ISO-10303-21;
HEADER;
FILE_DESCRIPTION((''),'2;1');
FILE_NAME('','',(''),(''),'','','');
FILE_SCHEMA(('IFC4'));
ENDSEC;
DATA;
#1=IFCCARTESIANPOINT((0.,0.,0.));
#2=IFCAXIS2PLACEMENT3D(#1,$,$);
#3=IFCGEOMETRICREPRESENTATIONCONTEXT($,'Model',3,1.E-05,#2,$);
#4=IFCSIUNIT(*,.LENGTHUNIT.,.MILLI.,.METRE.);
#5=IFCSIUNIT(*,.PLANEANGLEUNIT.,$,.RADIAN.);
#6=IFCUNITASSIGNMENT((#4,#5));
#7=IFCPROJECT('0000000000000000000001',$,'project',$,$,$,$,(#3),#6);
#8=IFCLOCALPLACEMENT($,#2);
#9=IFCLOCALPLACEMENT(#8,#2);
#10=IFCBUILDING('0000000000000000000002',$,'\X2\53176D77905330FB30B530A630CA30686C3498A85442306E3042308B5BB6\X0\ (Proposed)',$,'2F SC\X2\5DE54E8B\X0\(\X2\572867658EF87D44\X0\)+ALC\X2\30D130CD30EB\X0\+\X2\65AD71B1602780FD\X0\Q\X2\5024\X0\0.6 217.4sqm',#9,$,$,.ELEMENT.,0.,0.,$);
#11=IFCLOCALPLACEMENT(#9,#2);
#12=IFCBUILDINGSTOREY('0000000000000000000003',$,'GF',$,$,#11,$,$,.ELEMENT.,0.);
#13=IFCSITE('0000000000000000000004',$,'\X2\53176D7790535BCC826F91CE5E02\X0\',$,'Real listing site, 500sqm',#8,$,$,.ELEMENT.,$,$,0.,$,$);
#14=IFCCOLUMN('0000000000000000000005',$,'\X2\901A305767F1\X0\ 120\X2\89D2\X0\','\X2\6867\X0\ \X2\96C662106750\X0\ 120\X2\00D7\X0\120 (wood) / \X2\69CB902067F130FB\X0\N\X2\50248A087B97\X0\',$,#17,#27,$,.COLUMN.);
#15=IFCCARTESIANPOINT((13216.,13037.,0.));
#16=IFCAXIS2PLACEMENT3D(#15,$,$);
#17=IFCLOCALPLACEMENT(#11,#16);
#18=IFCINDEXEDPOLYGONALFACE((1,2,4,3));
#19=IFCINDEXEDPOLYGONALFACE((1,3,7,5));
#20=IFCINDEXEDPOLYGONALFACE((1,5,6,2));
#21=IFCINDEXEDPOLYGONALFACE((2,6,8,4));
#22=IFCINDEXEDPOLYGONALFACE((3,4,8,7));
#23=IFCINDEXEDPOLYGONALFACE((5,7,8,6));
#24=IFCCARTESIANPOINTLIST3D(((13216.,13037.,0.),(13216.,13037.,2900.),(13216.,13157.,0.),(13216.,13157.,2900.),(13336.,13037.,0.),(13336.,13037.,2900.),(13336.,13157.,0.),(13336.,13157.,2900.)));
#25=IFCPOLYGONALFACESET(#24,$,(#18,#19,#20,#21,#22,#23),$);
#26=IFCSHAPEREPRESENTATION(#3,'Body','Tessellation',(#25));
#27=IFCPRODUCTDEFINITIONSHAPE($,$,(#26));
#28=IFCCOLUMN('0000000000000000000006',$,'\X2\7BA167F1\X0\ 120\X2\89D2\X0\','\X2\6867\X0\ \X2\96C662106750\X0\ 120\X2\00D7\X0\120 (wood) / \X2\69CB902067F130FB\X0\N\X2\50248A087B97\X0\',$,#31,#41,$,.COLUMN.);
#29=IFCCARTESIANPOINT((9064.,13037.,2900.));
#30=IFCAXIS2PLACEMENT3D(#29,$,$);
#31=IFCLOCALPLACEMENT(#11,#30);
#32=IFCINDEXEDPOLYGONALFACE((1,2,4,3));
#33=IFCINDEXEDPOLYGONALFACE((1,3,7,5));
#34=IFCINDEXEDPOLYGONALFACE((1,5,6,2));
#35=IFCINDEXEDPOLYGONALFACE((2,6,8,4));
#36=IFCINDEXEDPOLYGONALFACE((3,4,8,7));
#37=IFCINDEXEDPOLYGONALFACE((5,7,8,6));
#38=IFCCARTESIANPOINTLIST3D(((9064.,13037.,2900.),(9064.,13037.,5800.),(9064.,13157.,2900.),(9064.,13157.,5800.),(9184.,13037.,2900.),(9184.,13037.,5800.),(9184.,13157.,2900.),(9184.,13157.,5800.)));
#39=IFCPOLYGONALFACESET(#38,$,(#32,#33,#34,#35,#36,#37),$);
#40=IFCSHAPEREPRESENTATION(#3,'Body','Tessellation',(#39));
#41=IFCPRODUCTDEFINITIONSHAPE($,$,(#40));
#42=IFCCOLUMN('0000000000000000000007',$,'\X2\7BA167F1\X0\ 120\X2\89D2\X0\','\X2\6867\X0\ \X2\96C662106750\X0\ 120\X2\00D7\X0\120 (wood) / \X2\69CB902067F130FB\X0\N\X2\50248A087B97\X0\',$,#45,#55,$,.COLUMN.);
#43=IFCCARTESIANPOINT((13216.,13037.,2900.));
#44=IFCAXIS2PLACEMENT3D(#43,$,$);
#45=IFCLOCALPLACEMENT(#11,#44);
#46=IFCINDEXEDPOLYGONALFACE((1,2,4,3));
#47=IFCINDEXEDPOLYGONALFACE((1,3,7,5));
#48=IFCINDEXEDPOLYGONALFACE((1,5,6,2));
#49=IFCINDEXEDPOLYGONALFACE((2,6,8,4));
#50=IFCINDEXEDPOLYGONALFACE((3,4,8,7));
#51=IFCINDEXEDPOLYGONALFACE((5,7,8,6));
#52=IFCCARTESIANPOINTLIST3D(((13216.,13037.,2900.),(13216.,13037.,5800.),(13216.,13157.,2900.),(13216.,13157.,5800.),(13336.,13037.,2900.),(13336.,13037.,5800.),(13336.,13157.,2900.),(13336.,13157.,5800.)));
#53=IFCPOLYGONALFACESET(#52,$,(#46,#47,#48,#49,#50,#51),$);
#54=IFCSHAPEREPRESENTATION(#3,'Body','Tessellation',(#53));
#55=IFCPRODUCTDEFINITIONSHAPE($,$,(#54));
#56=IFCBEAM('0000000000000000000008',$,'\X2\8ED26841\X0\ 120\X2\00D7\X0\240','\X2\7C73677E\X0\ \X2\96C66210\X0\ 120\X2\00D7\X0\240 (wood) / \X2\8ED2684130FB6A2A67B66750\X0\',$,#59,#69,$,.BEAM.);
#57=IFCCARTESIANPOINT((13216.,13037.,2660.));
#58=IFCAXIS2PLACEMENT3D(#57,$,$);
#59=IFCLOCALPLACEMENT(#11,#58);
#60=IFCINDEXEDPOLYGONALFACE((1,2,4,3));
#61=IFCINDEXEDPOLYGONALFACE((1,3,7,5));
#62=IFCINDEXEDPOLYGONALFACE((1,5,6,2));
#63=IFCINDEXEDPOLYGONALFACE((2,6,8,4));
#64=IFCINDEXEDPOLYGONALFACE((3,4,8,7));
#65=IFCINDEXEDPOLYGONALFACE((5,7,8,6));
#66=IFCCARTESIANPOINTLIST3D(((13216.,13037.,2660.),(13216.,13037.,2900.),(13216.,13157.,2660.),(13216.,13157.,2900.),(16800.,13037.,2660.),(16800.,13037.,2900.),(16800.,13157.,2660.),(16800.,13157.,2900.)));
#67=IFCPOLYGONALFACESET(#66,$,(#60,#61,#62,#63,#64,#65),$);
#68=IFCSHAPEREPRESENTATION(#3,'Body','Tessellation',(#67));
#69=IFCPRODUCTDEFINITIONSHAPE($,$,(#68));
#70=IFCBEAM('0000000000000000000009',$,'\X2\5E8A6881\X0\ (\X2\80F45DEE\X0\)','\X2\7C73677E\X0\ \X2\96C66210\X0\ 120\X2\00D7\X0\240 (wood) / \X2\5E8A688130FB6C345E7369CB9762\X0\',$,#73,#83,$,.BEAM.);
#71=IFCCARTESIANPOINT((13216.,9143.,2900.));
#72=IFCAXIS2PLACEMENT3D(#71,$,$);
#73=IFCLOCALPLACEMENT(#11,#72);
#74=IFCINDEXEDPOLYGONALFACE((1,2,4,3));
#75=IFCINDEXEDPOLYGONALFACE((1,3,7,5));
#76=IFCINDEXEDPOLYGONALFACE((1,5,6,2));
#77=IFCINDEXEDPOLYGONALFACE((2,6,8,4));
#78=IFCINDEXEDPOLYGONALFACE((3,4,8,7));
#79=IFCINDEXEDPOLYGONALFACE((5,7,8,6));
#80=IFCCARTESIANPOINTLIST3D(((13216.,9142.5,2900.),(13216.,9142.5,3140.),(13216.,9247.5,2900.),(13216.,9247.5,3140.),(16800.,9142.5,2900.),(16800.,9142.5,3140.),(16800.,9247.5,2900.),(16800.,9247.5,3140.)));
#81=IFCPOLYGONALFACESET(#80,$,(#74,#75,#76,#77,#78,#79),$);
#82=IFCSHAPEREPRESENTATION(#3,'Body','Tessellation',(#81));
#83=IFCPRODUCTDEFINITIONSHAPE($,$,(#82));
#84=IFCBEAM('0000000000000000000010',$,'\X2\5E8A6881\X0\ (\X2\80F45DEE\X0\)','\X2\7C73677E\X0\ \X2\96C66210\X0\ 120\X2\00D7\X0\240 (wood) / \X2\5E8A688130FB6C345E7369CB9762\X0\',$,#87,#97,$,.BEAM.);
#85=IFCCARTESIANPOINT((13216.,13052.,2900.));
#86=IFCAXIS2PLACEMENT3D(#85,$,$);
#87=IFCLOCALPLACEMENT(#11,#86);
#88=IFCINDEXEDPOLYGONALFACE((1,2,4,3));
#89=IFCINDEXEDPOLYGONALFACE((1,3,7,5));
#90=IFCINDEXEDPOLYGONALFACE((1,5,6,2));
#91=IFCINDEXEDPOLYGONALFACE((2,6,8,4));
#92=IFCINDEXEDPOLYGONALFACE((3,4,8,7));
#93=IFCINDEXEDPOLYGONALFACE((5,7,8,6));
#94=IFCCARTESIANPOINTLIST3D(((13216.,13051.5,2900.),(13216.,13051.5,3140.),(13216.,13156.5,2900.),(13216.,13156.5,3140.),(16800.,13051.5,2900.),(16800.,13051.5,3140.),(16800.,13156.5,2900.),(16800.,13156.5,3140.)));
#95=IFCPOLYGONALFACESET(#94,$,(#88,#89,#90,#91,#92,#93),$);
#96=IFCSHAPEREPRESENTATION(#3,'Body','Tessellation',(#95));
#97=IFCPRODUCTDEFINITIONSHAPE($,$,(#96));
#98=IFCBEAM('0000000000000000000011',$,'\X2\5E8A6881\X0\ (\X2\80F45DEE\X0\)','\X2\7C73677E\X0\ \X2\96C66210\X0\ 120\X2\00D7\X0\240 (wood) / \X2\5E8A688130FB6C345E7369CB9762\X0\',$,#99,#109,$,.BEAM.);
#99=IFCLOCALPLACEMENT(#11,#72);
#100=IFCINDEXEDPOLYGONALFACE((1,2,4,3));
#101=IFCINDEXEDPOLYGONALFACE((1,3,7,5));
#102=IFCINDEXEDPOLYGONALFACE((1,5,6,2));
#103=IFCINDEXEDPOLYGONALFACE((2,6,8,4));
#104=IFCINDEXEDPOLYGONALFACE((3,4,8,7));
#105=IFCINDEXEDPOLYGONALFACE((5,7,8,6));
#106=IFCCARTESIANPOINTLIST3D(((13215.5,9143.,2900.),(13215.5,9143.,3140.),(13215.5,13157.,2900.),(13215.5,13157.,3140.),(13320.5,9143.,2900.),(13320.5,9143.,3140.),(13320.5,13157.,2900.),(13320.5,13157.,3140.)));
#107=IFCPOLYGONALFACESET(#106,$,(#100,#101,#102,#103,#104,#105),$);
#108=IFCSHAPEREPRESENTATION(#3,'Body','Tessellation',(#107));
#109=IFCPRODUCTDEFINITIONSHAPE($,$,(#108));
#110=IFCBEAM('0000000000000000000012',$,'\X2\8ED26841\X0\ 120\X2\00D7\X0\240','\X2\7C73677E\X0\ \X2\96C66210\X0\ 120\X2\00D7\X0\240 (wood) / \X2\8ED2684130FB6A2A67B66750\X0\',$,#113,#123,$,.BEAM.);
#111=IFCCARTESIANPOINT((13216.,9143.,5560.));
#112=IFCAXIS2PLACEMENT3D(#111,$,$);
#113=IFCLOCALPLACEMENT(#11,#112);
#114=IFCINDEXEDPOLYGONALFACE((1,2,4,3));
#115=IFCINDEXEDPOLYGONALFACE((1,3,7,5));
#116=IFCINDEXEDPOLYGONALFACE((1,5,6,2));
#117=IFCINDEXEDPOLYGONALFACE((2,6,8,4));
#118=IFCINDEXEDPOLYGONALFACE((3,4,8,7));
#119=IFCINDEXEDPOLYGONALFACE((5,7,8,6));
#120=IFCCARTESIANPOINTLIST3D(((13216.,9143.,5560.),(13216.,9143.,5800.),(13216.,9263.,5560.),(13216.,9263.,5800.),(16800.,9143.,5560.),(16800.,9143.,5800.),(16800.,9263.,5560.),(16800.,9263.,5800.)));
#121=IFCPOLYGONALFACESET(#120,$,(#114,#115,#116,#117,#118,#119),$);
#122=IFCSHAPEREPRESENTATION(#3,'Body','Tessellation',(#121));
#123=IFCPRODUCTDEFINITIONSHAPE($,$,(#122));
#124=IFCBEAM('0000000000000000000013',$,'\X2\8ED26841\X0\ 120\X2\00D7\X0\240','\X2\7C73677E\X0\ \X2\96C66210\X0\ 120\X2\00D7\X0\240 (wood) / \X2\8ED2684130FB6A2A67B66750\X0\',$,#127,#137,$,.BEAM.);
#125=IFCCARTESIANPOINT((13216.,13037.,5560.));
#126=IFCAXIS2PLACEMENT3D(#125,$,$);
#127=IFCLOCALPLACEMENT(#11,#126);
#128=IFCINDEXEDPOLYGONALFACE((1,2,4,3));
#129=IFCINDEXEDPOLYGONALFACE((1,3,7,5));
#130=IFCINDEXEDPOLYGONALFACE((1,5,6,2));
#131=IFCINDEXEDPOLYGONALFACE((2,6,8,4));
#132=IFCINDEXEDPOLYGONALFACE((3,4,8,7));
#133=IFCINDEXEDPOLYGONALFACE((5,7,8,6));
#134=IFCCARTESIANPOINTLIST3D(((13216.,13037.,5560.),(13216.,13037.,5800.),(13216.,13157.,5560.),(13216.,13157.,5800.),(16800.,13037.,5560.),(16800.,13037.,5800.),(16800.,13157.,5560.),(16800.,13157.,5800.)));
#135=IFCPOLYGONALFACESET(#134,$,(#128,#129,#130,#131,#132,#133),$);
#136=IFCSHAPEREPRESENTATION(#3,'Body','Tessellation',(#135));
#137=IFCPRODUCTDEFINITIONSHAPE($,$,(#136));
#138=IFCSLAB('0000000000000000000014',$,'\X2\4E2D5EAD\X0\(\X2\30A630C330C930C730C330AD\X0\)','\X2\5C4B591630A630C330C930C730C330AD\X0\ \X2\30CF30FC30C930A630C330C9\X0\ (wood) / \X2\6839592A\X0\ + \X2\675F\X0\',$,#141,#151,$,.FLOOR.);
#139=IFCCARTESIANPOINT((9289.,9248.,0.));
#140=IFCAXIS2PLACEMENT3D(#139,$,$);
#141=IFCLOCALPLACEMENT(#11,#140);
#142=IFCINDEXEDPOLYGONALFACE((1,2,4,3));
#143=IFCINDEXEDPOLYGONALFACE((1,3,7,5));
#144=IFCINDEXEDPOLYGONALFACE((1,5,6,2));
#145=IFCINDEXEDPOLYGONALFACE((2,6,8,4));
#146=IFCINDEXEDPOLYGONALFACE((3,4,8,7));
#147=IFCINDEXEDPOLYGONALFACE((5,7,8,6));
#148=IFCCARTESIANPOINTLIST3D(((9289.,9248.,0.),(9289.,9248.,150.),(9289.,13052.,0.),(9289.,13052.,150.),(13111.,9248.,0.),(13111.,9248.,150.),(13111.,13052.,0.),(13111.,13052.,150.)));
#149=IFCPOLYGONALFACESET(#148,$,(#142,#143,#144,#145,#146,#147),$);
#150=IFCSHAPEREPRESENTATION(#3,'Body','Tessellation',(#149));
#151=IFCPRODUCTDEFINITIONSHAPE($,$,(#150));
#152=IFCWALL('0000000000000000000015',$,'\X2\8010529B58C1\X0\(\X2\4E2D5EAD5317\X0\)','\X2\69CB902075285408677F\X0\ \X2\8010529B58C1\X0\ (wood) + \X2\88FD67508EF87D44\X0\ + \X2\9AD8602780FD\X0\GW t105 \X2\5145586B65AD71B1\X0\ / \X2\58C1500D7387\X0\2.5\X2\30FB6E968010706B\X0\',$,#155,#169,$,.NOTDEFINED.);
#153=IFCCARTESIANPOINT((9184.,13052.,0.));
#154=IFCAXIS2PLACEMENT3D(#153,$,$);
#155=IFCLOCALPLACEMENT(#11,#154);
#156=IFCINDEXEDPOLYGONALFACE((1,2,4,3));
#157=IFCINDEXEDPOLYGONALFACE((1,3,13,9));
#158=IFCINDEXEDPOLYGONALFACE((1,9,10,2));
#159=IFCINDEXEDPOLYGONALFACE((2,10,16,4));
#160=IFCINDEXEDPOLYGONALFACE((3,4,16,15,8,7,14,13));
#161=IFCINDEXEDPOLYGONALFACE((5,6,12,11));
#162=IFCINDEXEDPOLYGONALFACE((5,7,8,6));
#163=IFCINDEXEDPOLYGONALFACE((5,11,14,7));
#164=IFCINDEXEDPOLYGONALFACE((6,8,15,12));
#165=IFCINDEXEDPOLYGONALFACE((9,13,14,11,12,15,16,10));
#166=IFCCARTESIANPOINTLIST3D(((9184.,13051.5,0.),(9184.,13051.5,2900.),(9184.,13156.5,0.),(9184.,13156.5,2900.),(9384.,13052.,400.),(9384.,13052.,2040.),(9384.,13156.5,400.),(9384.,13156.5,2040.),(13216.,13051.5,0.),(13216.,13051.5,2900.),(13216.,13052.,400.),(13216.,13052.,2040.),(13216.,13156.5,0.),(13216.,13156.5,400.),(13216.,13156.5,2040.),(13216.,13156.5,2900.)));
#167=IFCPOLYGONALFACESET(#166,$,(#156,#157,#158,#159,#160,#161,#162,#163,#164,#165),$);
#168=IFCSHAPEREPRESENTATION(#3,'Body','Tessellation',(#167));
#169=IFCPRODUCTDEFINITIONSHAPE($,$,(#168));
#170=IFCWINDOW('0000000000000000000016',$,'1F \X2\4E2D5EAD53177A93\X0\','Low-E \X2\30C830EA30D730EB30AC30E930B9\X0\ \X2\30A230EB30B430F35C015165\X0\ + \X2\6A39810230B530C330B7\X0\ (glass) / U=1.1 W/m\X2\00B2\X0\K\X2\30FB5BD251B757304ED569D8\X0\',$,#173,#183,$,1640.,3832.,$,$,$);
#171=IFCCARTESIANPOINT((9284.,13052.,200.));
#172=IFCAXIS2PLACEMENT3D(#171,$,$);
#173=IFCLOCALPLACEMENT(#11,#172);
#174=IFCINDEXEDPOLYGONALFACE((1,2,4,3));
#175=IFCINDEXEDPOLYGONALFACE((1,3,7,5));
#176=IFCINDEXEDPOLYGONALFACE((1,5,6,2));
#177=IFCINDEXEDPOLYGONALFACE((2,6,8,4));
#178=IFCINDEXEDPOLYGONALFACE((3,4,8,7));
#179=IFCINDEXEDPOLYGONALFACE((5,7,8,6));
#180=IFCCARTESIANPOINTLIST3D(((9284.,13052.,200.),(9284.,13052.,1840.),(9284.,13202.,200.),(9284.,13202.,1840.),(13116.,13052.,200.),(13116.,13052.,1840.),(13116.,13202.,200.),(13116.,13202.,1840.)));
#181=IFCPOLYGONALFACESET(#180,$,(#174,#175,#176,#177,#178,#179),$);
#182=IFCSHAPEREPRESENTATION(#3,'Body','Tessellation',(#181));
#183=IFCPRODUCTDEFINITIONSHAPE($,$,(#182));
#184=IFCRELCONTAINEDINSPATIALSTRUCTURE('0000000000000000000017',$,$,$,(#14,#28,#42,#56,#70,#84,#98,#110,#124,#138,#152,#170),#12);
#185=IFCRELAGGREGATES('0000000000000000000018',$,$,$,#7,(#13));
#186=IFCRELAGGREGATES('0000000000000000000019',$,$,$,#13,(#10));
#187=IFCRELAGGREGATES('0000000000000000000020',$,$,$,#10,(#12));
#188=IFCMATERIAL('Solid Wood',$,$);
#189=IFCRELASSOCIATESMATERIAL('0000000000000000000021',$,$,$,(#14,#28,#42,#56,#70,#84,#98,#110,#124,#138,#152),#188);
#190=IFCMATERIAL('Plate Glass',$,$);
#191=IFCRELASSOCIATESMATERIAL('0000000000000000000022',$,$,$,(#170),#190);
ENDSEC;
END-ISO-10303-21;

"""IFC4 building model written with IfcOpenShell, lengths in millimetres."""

from ifc_helpers import new_model, si_unit, frame, frame_2d, origin, place, context, project, spatial, rectangle, extrude, material, element, fill, save


model = new_model("IFC4")

# Units and contexts
model_context = context("Model", 3, precision=1e-05, world=origin())
ifc_project = project(units=[si_unit("LENGTHUNIT", "METRE", prefix="MILLI"), si_unit("PLANEANGLEUNIT", "RADIAN")], contexts=[model_context])

# Site, building, storey
site_placement = place(None, origin())
site = spatial("IfcSite", under=ifc_project, at=site_placement, Name="北海道富良野市", ObjectType="Real listing site, 500sqm", CompositionType="ELEMENT", RefElevation=0.0)
building_placement = place(site_placement, origin())
building = spatial("IfcBuilding", under=site, at=building_placement, Name="北海道・サウナと水風呂のある家 (Proposed)", ObjectType="2F SC工事(在来軸組)+ALCパネル+断熱性能Q値0.6 217.4sqm", CompositionType="ELEMENT", ElevationOfRefHeight=0.0, ElevationOfTerrain=0.0)
storey_placement = place(building_placement, origin())
storey = spatial("IfcBuildingStorey", under=building, at=storey_placement, Name="GF", CompositionType="ELEMENT", Elevation=0.0)

# Columns
ifc_material_1 = material(Name="Solid Wood")
column_1_placement = place(storey_placement, frame((13216.0, 13037.0, 0.0)))
element("IfcColumn", 1, at=column_1_placement, inside=storey, material=ifc_material_1, Name="通し柱 120角", Description="桧 集成材 120×120 (wood) / 構造柱・N値計算", PredefinedType="COLUMN", context=model_context, shape_type="SweptSolid", body=[
    extrude(rectangle(XDim=120.0, YDim=120.0, at=frame_2d((60.0, 60.0))), frame((13216.0, 13037.0, 0.0)), (0.0, 0.0, 1.0), 2900.0),
])
column_2_placement = place(storey_placement, frame((9064.0, 13037.0, 2900.0)))
element("IfcColumn", 2, at=column_2_placement, inside=storey, material=ifc_material_1, Name="管柱 120角", Description="桧 集成材 120×120 (wood) / 構造柱・N値計算", PredefinedType="COLUMN", context=model_context, shape_type="SweptSolid", body=[
    extrude(rectangle(XDim=120.0, YDim=120.0, at=frame_2d((60.0, 60.0))), frame((9064.0, 13037.0, 2900.0)), (0.0, 0.0, 1.0), 2900.0),
])
column_3_placement = place(storey_placement, frame((13216.0, 13037.0, 2900.0)))
element("IfcColumn", 3, at=column_3_placement, inside=storey, material=ifc_material_1, Name="管柱 120角", Description="桧 集成材 120×120 (wood) / 構造柱・N値計算", PredefinedType="COLUMN", context=model_context, shape_type="SweptSolid", body=[
    extrude(rectangle(XDim=120.0, YDim=120.0, at=frame_2d((60.0, 60.0))), frame((13216.0, 13037.0, 2900.0)), (0.0, 0.0, 1.0), 2900.0),
])

# Beams
beam_1_placement = place(storey_placement, frame((13216.0, 13037.0, 2660.0)))
element("IfcBeam", 4, at=beam_1_placement, inside=storey, material=ifc_material_1, Name="軒桁 120×240", Description="米松 集成 120×240 (wood) / 軒桁・横架材", PredefinedType="BEAM", context=model_context, shape_type="SweptSolid", body=[
    extrude(rectangle(XDim=3584.0, YDim=120.0, at=frame_2d((1792.0, 60.0))), frame((13216.0, 13037.0, 2660.0)), (0.0, 0.0, 1.0), 240.0),
])
beam_2_placement = place(storey_placement, frame((13216.0, 9143.0, 2900.0)))
element("IfcBeam", 5, at=beam_2_placement, inside=storey, material=ifc_material_1, Name="床梁 (胴差)", Description="米松 集成 120×240 (wood) / 床梁・水平構面", PredefinedType="BEAM", context=model_context, shape_type="SweptSolid", body=[
    extrude(rectangle(XDim=3584.0, YDim=105.0, at=frame_2d((1792.0, 52.0))), frame((13216.0, 9143.0, 2900.0)), (0.0, 0.0, 1.0), 240.0),
])
beam_3_placement = place(storey_placement, frame((13216.0, 13052.0, 2900.0)))
element("IfcBeam", 6, at=beam_3_placement, inside=storey, material=ifc_material_1, Name="床梁 (胴差)", Description="米松 集成 120×240 (wood) / 床梁・水平構面", PredefinedType="BEAM", context=model_context, shape_type="SweptSolid", body=[
    extrude(rectangle(XDim=3584.0, YDim=105.0, at=frame_2d((1792.0, 52.0))), frame((13216.0, 13052.0, 2900.0)), (0.0, 0.0, 1.0), 240.0),
])
beam_4_placement = place(storey_placement, frame((13216.0, 9143.0, 2900.0)))
element("IfcBeam", 7, at=beam_4_placement, inside=storey, material=ifc_material_1, Name="床梁 (胴差)", Description="米松 集成 120×240 (wood) / 床梁・水平構面", PredefinedType="BEAM", context=model_context, shape_type="SweptSolid", body=[
    extrude(rectangle(XDim=105.0, YDim=4014.0, at=frame_2d((52.0, 2007.0))), frame((13216.0, 9143.0, 2900.0)), (0.0, 0.0, 1.0), 240.0),
])
beam_5_placement = place(storey_placement, frame((13216.0, 9143.0, 5560.0)))
element("IfcBeam", 8, at=beam_5_placement, inside=storey, material=ifc_material_1, Name="軒桁 120×240", Description="米松 集成 120×240 (wood) / 軒桁・横架材", PredefinedType="BEAM", context=model_context, shape_type="SweptSolid", body=[
    extrude(rectangle(XDim=3584.0, YDim=120.0, at=frame_2d((1792.0, 60.0))), frame((13216.0, 9143.0, 5560.0)), (0.0, 0.0, 1.0), 240.0),
])
beam_6_placement = place(storey_placement, frame((13216.0, 13037.0, 5560.0)))
element("IfcBeam", 9, at=beam_6_placement, inside=storey, material=ifc_material_1, Name="軒桁 120×240", Description="米松 集成 120×240 (wood) / 軒桁・横架材", PredefinedType="BEAM", context=model_context, shape_type="SweptSolid", body=[
    extrude(rectangle(XDim=3584.0, YDim=120.0, at=frame_2d((1792.0, 60.0))), frame((13216.0, 13037.0, 5560.0)), (0.0, 0.0, 1.0), 240.0),
])

# Slab
slab_placement = place(storey_placement, frame((9289.0, 9248.0, 0.0)))
element("IfcSlab", 10, at=slab_placement, inside=storey, material=ifc_material_1, Name="中庭(ウッドデッキ)", Description="屋外ウッドデッキ ハードウッド (wood) / 根太 + 束", PredefinedType="FLOOR", context=model_context, shape_type="SweptSolid", body=[
    extrude(rectangle(XDim=3822.0, YDim=3804.0, at=frame_2d((1911.0, 1902.0))), frame((9289.0, 9248.0, 0.0)), (0.0, 0.0, 1.0), 150.0),
])

# Wall, opening, window
wall_1_placement = place(storey_placement, frame((9184.0, 13052.0, 0.0)))
wall_1 = element("IfcWall", 11, at=wall_1_placement, inside=storey, material=ifc_material_1, Name="耐力壁(中庭北)", Description="構造用合板 耐力壁 (wood) + 製材軸組 + 高性能GW t105 充填断熱 / 壁倍率2.5・準耐火", PredefinedType="NOTDEFINED", context=model_context, shape_type="SweptSolid", body=[
    extrude(rectangle(XDim=4032.0, YDim=105.0, at=frame_2d((2016.0, 52.0))), frame((9184.0, 13052.0, 0.0)), (0.0, 0.0, 1.0), 2900.0),
])
opening_1_placement = place(storey_placement, frame((9284.0, 13052.0, 200.0)))
opening_1 = element("IfcOpeningElement", 12, at=opening_1_placement, cuts=wall_1, PredefinedType="NOTDEFINED", context=model_context, shape_type="SweptSolid", body=[
    extrude(rectangle(XDim=3832.0, YDim=150.0, at=frame_2d((1916.0, 75.0))), frame((9284.0, 13052.0, 200.0)), (0.0, 0.0, 1.0), 1640.0),
])
ifc_material_2 = material(Name="Plate Glass")
window_1_placement = place(storey_placement, frame((9284.0, 13052.0, 200.0)))
window_1 = element("IfcWindow", 13, at=window_1_placement, inside=storey, material=ifc_material_2, Name="1F 中庭北窓", Description="Low-E トリプルガラス アルゴン封入 + 樹脂サッシ (glass) / U=1.1 W/m²K・寒冷地仕様", OverallHeight=1640.0, OverallWidth=3832.0, context=model_context, shape_type="SweptSolid", body=[
    extrude(rectangle(XDim=3832.0, YDim=150.0, at=frame_2d((1916.0, 75.0))), frame((9284.0, 13052.0, 200.0)), (0.0, 0.0, 1.0), 1640.0),
])
fill(opening_1, window_1)

save(model, "model.ifc")
